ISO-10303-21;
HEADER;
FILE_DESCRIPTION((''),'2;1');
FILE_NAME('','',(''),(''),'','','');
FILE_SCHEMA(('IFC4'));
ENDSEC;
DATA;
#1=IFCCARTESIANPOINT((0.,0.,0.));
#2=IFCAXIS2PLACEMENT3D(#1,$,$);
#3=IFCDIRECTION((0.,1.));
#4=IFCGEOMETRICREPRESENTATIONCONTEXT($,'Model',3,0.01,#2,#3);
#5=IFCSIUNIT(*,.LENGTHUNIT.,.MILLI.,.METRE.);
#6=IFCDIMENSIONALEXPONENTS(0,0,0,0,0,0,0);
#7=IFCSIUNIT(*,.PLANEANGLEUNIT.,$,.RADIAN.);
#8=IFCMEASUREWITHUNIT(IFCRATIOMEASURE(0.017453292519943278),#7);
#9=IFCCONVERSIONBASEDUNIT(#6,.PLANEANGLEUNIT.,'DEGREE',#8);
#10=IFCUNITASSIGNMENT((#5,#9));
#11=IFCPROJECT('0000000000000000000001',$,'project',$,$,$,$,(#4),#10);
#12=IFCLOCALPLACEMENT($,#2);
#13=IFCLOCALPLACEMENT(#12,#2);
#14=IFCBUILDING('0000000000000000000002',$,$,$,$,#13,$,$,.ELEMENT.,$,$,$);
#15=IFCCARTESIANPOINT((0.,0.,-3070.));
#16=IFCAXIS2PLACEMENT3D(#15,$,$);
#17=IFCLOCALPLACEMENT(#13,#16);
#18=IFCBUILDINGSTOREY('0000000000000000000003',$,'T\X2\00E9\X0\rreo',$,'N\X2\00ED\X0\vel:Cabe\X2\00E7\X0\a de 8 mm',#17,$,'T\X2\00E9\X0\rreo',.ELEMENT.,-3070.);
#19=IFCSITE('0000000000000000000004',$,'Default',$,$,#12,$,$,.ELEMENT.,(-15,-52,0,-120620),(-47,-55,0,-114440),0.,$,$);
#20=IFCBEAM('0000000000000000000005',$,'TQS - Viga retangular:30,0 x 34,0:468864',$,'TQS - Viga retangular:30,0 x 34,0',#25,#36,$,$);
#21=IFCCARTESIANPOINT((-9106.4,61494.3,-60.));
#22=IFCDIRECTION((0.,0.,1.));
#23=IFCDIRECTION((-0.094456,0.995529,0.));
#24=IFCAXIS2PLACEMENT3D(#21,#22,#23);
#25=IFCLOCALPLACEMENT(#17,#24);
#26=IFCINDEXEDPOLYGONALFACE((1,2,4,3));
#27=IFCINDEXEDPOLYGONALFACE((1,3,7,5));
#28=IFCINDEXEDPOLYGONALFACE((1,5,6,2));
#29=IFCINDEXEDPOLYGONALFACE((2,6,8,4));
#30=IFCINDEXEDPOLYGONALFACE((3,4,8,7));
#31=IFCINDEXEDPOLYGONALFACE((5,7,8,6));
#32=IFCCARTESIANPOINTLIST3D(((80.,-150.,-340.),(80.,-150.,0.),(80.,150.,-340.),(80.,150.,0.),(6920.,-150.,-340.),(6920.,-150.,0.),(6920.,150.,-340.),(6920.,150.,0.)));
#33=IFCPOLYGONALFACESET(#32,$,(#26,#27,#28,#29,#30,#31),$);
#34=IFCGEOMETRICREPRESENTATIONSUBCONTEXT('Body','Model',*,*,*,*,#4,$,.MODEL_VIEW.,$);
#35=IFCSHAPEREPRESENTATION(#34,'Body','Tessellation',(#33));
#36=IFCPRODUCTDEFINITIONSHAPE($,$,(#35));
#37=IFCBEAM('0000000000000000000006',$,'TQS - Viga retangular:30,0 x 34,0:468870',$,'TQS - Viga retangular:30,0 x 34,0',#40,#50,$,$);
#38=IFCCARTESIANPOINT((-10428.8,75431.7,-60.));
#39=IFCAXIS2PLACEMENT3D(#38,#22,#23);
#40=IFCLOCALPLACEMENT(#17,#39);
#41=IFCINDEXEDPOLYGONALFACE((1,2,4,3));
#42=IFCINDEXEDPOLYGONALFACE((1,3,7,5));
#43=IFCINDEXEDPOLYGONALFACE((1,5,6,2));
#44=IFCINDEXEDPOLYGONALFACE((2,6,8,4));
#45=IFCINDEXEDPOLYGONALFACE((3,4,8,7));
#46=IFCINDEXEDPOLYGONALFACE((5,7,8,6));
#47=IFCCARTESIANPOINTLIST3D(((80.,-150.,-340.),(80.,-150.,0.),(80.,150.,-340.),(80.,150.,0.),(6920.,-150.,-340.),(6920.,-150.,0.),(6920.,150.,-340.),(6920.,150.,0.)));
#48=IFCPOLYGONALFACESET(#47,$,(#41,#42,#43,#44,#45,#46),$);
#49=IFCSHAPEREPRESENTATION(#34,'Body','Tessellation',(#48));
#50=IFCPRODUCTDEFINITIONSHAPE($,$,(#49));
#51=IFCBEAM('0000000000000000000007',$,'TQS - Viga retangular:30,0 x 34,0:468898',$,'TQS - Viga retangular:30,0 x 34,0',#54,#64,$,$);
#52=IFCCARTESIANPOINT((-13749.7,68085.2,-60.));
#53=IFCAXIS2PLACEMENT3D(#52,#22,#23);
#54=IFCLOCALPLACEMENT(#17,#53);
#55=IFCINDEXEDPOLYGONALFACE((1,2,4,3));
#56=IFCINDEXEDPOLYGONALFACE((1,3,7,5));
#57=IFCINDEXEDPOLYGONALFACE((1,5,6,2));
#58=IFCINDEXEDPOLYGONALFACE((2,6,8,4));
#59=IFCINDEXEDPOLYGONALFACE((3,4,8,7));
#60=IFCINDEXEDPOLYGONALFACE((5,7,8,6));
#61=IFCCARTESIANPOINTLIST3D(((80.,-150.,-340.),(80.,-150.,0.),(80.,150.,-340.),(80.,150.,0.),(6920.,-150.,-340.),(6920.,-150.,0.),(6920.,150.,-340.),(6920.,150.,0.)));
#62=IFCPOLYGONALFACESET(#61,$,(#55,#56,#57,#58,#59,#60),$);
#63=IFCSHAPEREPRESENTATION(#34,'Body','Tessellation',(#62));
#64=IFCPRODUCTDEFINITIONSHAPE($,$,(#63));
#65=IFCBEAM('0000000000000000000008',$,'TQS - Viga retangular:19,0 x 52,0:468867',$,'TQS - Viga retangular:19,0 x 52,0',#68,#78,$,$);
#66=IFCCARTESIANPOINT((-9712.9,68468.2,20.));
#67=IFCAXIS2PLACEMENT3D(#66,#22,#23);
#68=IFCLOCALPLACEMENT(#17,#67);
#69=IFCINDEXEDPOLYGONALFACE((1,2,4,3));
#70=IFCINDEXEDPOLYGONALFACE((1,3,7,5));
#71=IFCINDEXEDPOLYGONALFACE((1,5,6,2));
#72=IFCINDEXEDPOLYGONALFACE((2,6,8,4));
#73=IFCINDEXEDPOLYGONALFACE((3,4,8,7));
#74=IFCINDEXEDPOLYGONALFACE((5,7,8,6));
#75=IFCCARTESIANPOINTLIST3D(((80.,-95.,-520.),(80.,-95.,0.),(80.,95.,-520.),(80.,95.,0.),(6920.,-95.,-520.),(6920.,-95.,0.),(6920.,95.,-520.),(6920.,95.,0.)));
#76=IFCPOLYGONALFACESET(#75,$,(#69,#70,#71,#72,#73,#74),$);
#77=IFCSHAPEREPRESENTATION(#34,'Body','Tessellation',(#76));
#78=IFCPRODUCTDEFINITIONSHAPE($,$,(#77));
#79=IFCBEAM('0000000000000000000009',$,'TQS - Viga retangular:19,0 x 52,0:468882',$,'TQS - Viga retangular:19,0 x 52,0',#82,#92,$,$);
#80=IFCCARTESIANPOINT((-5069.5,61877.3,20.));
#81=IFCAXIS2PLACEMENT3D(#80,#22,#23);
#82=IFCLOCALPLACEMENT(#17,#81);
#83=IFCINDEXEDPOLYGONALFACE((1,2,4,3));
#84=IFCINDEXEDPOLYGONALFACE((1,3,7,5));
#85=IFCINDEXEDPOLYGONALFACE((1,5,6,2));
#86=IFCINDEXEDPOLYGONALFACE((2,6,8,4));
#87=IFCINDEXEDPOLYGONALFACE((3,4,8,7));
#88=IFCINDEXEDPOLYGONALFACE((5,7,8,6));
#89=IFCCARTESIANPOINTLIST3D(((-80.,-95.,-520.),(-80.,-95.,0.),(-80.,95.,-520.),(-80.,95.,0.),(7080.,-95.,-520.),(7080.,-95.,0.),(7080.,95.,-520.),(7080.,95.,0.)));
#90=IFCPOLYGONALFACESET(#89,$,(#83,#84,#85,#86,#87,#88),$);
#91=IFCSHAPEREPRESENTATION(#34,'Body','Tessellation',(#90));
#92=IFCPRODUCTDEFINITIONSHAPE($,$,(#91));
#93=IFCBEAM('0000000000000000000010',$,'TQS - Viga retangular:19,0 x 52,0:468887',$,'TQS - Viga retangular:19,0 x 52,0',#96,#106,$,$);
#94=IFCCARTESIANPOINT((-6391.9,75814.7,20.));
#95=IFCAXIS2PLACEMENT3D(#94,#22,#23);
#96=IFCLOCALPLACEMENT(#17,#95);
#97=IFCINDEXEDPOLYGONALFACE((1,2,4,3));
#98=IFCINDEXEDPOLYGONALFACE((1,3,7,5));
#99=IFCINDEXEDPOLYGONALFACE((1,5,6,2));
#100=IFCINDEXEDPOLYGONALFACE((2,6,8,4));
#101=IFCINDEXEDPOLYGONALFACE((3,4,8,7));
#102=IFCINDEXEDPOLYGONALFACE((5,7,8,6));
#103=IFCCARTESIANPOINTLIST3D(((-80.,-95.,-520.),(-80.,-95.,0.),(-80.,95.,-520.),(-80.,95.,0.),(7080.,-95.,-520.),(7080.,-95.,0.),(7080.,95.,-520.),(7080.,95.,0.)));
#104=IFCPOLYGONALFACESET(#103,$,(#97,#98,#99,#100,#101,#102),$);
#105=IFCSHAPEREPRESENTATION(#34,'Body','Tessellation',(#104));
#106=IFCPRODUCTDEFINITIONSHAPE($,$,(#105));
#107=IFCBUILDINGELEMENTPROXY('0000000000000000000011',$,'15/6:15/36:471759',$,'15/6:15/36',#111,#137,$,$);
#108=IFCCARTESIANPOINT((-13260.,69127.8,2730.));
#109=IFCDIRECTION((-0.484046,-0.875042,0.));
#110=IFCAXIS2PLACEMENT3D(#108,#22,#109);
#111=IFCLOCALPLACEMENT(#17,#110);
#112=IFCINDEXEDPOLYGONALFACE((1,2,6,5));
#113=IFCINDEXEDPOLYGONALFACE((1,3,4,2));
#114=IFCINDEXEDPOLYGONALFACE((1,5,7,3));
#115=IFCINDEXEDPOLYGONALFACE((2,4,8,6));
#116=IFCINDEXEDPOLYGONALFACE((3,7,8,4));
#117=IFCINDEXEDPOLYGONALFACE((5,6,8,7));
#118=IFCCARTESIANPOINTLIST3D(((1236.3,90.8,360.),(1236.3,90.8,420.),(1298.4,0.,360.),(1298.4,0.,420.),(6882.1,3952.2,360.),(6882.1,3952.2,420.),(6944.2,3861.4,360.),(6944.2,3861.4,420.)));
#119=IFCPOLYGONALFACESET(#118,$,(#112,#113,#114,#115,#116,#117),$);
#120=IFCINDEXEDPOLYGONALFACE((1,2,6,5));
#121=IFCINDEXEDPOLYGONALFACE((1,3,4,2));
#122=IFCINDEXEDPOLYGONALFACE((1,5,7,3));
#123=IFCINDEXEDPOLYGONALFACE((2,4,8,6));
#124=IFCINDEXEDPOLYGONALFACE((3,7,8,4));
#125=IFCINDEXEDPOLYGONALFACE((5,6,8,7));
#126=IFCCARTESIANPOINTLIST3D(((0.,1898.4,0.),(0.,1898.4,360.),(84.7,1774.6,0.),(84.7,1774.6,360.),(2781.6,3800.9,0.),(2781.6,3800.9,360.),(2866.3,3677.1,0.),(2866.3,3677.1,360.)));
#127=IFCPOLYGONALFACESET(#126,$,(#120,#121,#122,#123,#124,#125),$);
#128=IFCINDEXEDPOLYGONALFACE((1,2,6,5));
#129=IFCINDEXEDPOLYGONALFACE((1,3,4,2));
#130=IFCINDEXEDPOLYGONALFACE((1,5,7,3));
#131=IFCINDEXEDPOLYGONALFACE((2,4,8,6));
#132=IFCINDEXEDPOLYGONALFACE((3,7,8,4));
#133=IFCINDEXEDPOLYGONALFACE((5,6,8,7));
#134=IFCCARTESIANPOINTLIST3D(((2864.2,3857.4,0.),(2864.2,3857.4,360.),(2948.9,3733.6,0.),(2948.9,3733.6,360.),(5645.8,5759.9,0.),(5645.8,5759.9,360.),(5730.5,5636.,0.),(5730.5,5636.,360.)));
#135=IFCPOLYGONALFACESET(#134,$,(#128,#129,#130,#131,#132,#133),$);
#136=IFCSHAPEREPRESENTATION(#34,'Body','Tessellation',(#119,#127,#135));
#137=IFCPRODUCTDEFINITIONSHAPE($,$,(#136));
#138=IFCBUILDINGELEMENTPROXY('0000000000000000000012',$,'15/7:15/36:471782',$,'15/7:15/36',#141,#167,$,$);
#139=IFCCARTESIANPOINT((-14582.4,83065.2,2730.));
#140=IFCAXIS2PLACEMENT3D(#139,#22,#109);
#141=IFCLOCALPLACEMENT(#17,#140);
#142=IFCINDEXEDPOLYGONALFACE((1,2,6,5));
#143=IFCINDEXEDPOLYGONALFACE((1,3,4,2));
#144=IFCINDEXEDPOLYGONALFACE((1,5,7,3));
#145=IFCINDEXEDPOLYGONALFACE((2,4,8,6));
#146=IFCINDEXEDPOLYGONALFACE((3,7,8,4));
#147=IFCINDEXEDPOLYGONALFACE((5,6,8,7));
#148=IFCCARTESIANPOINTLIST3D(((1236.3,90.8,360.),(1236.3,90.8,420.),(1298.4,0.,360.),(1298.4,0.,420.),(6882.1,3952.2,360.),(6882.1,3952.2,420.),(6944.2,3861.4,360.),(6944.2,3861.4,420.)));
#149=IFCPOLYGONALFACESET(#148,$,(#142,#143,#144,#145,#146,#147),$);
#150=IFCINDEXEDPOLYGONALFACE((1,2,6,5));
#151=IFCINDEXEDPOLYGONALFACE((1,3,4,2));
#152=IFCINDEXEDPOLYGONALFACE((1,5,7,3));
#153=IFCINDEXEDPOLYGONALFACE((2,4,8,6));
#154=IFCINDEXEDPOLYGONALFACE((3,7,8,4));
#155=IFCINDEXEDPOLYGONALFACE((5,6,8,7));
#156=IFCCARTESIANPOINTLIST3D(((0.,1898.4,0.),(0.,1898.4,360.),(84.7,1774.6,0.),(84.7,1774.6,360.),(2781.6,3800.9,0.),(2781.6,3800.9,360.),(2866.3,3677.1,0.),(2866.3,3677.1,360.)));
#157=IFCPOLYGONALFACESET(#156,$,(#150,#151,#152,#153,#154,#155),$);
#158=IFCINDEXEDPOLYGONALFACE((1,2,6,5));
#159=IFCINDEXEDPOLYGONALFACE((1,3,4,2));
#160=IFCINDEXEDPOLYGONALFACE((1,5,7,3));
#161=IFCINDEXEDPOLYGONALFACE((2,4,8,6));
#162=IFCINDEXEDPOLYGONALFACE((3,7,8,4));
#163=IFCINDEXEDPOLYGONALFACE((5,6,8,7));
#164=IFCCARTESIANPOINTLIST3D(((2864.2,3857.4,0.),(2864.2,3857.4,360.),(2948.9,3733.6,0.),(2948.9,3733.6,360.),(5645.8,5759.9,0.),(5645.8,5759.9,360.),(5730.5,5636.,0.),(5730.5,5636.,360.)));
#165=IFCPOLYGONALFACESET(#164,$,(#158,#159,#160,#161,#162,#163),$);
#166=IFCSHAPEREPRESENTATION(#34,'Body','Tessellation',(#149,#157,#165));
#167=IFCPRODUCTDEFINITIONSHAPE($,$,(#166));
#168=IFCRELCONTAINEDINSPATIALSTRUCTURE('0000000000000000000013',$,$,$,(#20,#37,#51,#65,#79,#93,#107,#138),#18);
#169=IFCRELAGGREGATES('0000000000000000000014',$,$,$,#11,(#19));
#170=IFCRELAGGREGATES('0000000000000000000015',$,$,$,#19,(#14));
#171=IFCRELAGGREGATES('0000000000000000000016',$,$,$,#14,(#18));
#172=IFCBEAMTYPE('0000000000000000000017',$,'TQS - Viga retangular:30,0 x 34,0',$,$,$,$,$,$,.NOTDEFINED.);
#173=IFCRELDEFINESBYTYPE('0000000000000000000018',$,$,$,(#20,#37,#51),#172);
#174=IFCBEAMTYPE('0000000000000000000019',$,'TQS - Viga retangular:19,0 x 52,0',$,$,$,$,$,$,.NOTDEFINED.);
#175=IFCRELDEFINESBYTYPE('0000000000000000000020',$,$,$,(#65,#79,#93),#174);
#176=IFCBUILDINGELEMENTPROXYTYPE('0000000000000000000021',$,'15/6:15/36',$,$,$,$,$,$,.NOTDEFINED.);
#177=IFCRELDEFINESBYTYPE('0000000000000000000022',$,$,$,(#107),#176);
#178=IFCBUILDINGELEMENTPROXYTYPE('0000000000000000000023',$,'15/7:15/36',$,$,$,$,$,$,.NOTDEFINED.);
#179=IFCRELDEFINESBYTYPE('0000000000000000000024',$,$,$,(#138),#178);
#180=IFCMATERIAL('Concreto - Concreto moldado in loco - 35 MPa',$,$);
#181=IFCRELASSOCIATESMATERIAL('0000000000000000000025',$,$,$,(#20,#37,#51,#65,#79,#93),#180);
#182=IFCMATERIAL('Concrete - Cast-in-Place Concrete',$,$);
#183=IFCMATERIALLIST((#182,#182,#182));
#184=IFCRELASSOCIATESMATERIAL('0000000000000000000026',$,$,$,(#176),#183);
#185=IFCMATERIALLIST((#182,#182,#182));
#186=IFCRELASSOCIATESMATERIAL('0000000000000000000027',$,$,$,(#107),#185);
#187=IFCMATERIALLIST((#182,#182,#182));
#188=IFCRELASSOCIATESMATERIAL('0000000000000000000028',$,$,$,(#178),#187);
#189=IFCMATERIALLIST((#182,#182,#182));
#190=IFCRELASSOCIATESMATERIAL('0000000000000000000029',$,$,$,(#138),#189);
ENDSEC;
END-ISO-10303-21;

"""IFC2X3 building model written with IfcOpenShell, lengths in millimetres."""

from ifc_helpers import new_model, entity, si_unit, converted_unit, direction, frame, frame_2d, origin, place, context, subcontext, project, spatial, rectangle, extrude, source, transform, mapped, material, material_list, type_object, type_shapes, element, save


model = new_model("IFC2X3")

# Units and contexts
model_context = context("Model", 3, precision=0.01, world=origin(), true_north=direction((0.0, 1.0)))
body_context = subcontext(model_context, "Body", "Model", "MODEL_VIEW")
ifc_project = project(units=[si_unit("LENGTHUNIT", "METRE", prefix="MILLI"), converted_unit("PLANEANGLEUNIT", "DEGREE", entity("IfcRatioMeasure", 0.017453292519943278), si_unit("PLANEANGLEUNIT", "RADIAN"), dimensions=[0, 0, 0, 0, 0, 0, 0])], contexts=[model_context])

# Site, building, storey
site_placement = place(None, origin())
site = spatial("IfcSite", under=ifc_project, at=site_placement, Name="Default", CompositionType="ELEMENT", RefLatitude=(-15, -52, 0, -120620), RefLongitude=(-47, -55, 0, -114440), RefElevation=0.0)
building_placement = place(site_placement, origin())
building = spatial("IfcBuilding", under=site, at=building_placement, CompositionType="ELEMENT")
storey_placement = place(building_placement, frame((0.0, 0.0, -3070.0)))
storey = spatial("IfcBuildingStorey", under=building, at=storey_placement, Name="Térreo", ObjectType="Nível:Cabeça de 8 mm", LongName="Térreo", CompositionType="ELEMENT", Elevation=-3070.0)

# Beams
ifc_material_1 = material(Name="Concreto - Concreto moldado in loco - 35 MPa")
beam_type_1 = type_object("IfcBeamType", Name="TQS - Viga retangular:30,0 x 34,0", PredefinedType="NOTDEFINED")
beam_1_placement = place(storey_placement, frame((-9106.4, 61494.3, -60.0), z_axis=(0.0, 0.0, 1.0), x_axis=(-0.094456, 0.995529, 0.0)))
element("IfcBeam", 1, at=beam_1_placement, inside=storey, type_object=beam_type_1, material=ifc_material_1, Name="TQS - Viga retangular:30,0 x 34,0:468864", ObjectType="TQS - Viga retangular:30,0 x 34,0", context=body_context, shape_type="SweptSolid", body=[
    extrude(rectangle(XDim=340.0, YDim=300.0, at=frame_2d((0.0, 0.0), x_axis=(1.0, 0.0))), frame((80.0, 0.0, -170.0), z_axis=(1.0, 0.0, 0.0), x_axis=(0.0, 0.0, -1.0)), (0.0, 0.0, 1.0), 6840.0),
])
beam_2_placement = place(storey_placement, frame((-10428.8, 75431.7, -60.0), z_axis=(0.0, 0.0, 1.0), x_axis=(-0.094456, 0.995529, 0.0)))
element("IfcBeam", 2, at=beam_2_placement, inside=storey, type_object=beam_type_1, material=ifc_material_1, Name="TQS - Viga retangular:30,0 x 34,0:468870", ObjectType="TQS - Viga retangular:30,0 x 34,0", context=body_context, shape_type="SweptSolid", body=[
    extrude(rectangle(XDim=340.0, YDim=300.0, at=frame_2d((0.0, 0.0), x_axis=(1.0, 0.0))), frame((80.0, 0.0, -170.0), z_axis=(1.0, 0.0, 0.0), x_axis=(0.0, 0.0, -1.0)), (0.0, 0.0, 1.0), 6840.0),
])
beam_3_placement = place(storey_placement, frame((-13749.7, 68085.2, -60.0), z_axis=(0.0, 0.0, 1.0), x_axis=(-0.094456, 0.995529, 0.0)))
element("IfcBeam", 3, at=beam_3_placement, inside=storey, type_object=beam_type_1, material=ifc_material_1, Name="TQS - Viga retangular:30,0 x 34,0:468898", ObjectType="TQS - Viga retangular:30,0 x 34,0", context=body_context, shape_type="SweptSolid", body=[
    extrude(rectangle(XDim=340.0, YDim=300.0, at=frame_2d((0.0, 0.0), x_axis=(1.0, 0.0))), frame((80.0, 0.0, -170.0), z_axis=(1.0, 0.0, 0.0), x_axis=(0.0, 0.0, -1.0)), (0.0, 0.0, 1.0), 6840.0),
])
beam_type_2 = type_object("IfcBeamType", Name="TQS - Viga retangular:19,0 x 52,0", PredefinedType="NOTDEFINED")
beam_4_placement = place(storey_placement, frame((-9712.9, 68468.2, 20.0), z_axis=(0.0, 0.0, 1.0), x_axis=(-0.094456, 0.995529, 0.0)))
element("IfcBeam", 4, at=beam_4_placement, inside=storey, type_object=beam_type_2, material=ifc_material_1, Name="TQS - Viga retangular:19,0 x 52,0:468867", ObjectType="TQS - Viga retangular:19,0 x 52,0", context=body_context, shape_type="SweptSolid", body=[
    extrude(rectangle(XDim=520.0, YDim=190.0, at=frame_2d((0.0, 0.0), x_axis=(1.0, 0.0))), frame((80.0, 0.0, -260.0), z_axis=(1.0, 0.0, 0.0), x_axis=(0.0, 0.0, -1.0)), (0.0, 0.0, 1.0), 6840.0),
])
beam_5_placement = place(storey_placement, frame((-5069.5, 61877.3, 20.0), z_axis=(0.0, 0.0, 1.0), x_axis=(-0.094456, 0.995529, 0.0)))
element("IfcBeam", 5, at=beam_5_placement, inside=storey, type_object=beam_type_2, material=ifc_material_1, Name="TQS - Viga retangular:19,0 x 52,0:468882", ObjectType="TQS - Viga retangular:19,0 x 52,0", context=body_context, shape_type="SweptSolid", body=[
    extrude(rectangle(XDim=520.0, YDim=190.0, at=frame_2d((0.0, 0.0), x_axis=(1.0, 0.0))), frame((-80.0, 0.0, -260.0), z_axis=(1.0, 0.0, 0.0), x_axis=(0.0, 0.0, -1.0)), (0.0, 0.0, 1.0), 7160.0),
])
beam_6_placement = place(storey_placement, frame((-6391.9, 75814.7, 20.0), z_axis=(0.0, 0.0, 1.0), x_axis=(-0.094456, 0.995529, 0.0)))
element("IfcBeam", 6, at=beam_6_placement, inside=storey, type_object=beam_type_2, material=ifc_material_1, Name="TQS - Viga retangular:19,0 x 52,0:468887", ObjectType="TQS - Viga retangular:19,0 x 52,0", context=body_context, shape_type="SweptSolid", body=[
    extrude(rectangle(XDim=520.0, YDim=190.0, at=frame_2d((0.0, 0.0), x_axis=(1.0, 0.0))), frame((-80.0, 0.0, -260.0), z_axis=(1.0, 0.0, 0.0), x_axis=(0.0, 0.0, -1.0)), (0.0, 0.0, 1.0), 7160.0),
])

# Building element proxies
ifc_material_2 = material(Name="Concrete - Cast-in-Place Concrete")
ifc_material_list_1 = material_list([ifc_material_2, ifc_material_2, ifc_material_2])
ifc_material_list_2 = material_list([ifc_material_2, ifc_material_2, ifc_material_2])
building_element_proxy_type_1 = type_object("IfcBuildingElementProxyType", Name="15/6:15/36", PredefinedType="NOTDEFINED", material=ifc_material_list_2)
shared_shape_1 = source(origin(), body_context, "Body", "SweptSolid", [
    extrude(rectangle(XDim=110.0, YDim=6840.0, at=frame_2d((0.0, 0.0), x_axis=(1.0, 0.0))), frame((4090.3, 1976.1, 360.0), z_axis=(0.0, 0.0, 1.0), x_axis=(-0.564535, 0.825409, 0.0)), (0.0, 0.0, 1.0), 60.0),
    extrude(rectangle(XDim=3370.0, YDim=150.0, at=frame_2d((0.0, 0.0), x_axis=(1.0, 0.0))), frame((1433.2, 2787.8, 0.0), z_axis=(0.0, 0.0, 1.0), x_axis=(0.825409, 0.564535, 0.0)), (0.0, 0.0, 1.0), 360.0),
    extrude(rectangle(XDim=3370.0, YDim=150.0, at=frame_2d((0.0, 0.0), x_axis=(1.0, 0.0))), frame((4297.3, 4746.7, 0.0), z_axis=(0.0, 0.0, 1.0), x_axis=(0.825409, 0.564535, 0.0)), (0.0, 0.0, 1.0), 360.0),
])
type_shapes(building_element_proxy_type_1, [shared_shape_1])
proxy_1_placement = place(storey_placement, frame((-13260.0, 69127.8, 2730.0), z_axis=(0.0, 0.0, 1.0), x_axis=(-0.484046, -0.875042, 0.0)))
element("IfcBuildingElementProxy", 7, at=proxy_1_placement, inside=storey, type_object=building_element_proxy_type_1, material=ifc_material_list_1, Name="15/6:15/36:471759", ObjectType="15/6:15/36", context=body_context, shape_type="MappedRepresentation", body=[
    mapped(shared_shape_1, transform((0.0, 0.0, 0.0), scale=1.0)),
])
ifc_material_list_3 = material_list([ifc_material_2, ifc_material_2, ifc_material_2])
ifc_material_list_4 = material_list([ifc_material_2, ifc_material_2, ifc_material_2])
building_element_proxy_type_2 = type_object("IfcBuildingElementProxyType", Name="15/7:15/36", PredefinedType="NOTDEFINED", material=ifc_material_list_4)
shared_shape_2 = source(origin(), body_context, "Body", "SweptSolid", [
    extrude(rectangle(XDim=110.0, YDim=6840.0, at=frame_2d((0.0, 0.0), x_axis=(1.0, 0.0))), frame((4090.3, 1976.1, 360.0), z_axis=(0.0, 0.0, 1.0), x_axis=(-0.564535, 0.825409, 0.0)), (0.0, 0.0, 1.0), 60.0),
    extrude(rectangle(XDim=3370.0, YDim=150.0, at=frame_2d((0.0, 0.0), x_axis=(1.0, 0.0))), frame((1433.2, 2787.8, 0.0), z_axis=(0.0, 0.0, 1.0), x_axis=(0.825409, 0.564535, 0.0)), (0.0, 0.0, 1.0), 360.0),
    extrude(rectangle(XDim=3370.0, YDim=150.0, at=frame_2d((0.0, 0.0), x_axis=(1.0, 0.0))), frame((4297.3, 4746.7, 0.0), z_axis=(0.0, 0.0, 1.0), x_axis=(0.825409, 0.564535, 0.0)), (0.0, 0.0, 1.0), 360.0),
])
type_shapes(building_element_proxy_type_2, [shared_shape_2])
proxy_2_placement = place(storey_placement, frame((-14582.4, 83065.2, 2730.0), z_axis=(0.0, 0.0, 1.0), x_axis=(-0.484046, -0.875042, 0.0)))
element("IfcBuildingElementProxy", 8, at=proxy_2_placement, inside=storey, type_object=building_element_proxy_type_2, material=ifc_material_list_3, Name="15/7:15/36:471782", ObjectType="15/7:15/36", context=body_context, shape_type="MappedRepresentation", body=[
    mapped(shared_shape_2, transform((0.0, 0.0, 0.0), scale=1.0)),
])

save(model, "model.ifc")
